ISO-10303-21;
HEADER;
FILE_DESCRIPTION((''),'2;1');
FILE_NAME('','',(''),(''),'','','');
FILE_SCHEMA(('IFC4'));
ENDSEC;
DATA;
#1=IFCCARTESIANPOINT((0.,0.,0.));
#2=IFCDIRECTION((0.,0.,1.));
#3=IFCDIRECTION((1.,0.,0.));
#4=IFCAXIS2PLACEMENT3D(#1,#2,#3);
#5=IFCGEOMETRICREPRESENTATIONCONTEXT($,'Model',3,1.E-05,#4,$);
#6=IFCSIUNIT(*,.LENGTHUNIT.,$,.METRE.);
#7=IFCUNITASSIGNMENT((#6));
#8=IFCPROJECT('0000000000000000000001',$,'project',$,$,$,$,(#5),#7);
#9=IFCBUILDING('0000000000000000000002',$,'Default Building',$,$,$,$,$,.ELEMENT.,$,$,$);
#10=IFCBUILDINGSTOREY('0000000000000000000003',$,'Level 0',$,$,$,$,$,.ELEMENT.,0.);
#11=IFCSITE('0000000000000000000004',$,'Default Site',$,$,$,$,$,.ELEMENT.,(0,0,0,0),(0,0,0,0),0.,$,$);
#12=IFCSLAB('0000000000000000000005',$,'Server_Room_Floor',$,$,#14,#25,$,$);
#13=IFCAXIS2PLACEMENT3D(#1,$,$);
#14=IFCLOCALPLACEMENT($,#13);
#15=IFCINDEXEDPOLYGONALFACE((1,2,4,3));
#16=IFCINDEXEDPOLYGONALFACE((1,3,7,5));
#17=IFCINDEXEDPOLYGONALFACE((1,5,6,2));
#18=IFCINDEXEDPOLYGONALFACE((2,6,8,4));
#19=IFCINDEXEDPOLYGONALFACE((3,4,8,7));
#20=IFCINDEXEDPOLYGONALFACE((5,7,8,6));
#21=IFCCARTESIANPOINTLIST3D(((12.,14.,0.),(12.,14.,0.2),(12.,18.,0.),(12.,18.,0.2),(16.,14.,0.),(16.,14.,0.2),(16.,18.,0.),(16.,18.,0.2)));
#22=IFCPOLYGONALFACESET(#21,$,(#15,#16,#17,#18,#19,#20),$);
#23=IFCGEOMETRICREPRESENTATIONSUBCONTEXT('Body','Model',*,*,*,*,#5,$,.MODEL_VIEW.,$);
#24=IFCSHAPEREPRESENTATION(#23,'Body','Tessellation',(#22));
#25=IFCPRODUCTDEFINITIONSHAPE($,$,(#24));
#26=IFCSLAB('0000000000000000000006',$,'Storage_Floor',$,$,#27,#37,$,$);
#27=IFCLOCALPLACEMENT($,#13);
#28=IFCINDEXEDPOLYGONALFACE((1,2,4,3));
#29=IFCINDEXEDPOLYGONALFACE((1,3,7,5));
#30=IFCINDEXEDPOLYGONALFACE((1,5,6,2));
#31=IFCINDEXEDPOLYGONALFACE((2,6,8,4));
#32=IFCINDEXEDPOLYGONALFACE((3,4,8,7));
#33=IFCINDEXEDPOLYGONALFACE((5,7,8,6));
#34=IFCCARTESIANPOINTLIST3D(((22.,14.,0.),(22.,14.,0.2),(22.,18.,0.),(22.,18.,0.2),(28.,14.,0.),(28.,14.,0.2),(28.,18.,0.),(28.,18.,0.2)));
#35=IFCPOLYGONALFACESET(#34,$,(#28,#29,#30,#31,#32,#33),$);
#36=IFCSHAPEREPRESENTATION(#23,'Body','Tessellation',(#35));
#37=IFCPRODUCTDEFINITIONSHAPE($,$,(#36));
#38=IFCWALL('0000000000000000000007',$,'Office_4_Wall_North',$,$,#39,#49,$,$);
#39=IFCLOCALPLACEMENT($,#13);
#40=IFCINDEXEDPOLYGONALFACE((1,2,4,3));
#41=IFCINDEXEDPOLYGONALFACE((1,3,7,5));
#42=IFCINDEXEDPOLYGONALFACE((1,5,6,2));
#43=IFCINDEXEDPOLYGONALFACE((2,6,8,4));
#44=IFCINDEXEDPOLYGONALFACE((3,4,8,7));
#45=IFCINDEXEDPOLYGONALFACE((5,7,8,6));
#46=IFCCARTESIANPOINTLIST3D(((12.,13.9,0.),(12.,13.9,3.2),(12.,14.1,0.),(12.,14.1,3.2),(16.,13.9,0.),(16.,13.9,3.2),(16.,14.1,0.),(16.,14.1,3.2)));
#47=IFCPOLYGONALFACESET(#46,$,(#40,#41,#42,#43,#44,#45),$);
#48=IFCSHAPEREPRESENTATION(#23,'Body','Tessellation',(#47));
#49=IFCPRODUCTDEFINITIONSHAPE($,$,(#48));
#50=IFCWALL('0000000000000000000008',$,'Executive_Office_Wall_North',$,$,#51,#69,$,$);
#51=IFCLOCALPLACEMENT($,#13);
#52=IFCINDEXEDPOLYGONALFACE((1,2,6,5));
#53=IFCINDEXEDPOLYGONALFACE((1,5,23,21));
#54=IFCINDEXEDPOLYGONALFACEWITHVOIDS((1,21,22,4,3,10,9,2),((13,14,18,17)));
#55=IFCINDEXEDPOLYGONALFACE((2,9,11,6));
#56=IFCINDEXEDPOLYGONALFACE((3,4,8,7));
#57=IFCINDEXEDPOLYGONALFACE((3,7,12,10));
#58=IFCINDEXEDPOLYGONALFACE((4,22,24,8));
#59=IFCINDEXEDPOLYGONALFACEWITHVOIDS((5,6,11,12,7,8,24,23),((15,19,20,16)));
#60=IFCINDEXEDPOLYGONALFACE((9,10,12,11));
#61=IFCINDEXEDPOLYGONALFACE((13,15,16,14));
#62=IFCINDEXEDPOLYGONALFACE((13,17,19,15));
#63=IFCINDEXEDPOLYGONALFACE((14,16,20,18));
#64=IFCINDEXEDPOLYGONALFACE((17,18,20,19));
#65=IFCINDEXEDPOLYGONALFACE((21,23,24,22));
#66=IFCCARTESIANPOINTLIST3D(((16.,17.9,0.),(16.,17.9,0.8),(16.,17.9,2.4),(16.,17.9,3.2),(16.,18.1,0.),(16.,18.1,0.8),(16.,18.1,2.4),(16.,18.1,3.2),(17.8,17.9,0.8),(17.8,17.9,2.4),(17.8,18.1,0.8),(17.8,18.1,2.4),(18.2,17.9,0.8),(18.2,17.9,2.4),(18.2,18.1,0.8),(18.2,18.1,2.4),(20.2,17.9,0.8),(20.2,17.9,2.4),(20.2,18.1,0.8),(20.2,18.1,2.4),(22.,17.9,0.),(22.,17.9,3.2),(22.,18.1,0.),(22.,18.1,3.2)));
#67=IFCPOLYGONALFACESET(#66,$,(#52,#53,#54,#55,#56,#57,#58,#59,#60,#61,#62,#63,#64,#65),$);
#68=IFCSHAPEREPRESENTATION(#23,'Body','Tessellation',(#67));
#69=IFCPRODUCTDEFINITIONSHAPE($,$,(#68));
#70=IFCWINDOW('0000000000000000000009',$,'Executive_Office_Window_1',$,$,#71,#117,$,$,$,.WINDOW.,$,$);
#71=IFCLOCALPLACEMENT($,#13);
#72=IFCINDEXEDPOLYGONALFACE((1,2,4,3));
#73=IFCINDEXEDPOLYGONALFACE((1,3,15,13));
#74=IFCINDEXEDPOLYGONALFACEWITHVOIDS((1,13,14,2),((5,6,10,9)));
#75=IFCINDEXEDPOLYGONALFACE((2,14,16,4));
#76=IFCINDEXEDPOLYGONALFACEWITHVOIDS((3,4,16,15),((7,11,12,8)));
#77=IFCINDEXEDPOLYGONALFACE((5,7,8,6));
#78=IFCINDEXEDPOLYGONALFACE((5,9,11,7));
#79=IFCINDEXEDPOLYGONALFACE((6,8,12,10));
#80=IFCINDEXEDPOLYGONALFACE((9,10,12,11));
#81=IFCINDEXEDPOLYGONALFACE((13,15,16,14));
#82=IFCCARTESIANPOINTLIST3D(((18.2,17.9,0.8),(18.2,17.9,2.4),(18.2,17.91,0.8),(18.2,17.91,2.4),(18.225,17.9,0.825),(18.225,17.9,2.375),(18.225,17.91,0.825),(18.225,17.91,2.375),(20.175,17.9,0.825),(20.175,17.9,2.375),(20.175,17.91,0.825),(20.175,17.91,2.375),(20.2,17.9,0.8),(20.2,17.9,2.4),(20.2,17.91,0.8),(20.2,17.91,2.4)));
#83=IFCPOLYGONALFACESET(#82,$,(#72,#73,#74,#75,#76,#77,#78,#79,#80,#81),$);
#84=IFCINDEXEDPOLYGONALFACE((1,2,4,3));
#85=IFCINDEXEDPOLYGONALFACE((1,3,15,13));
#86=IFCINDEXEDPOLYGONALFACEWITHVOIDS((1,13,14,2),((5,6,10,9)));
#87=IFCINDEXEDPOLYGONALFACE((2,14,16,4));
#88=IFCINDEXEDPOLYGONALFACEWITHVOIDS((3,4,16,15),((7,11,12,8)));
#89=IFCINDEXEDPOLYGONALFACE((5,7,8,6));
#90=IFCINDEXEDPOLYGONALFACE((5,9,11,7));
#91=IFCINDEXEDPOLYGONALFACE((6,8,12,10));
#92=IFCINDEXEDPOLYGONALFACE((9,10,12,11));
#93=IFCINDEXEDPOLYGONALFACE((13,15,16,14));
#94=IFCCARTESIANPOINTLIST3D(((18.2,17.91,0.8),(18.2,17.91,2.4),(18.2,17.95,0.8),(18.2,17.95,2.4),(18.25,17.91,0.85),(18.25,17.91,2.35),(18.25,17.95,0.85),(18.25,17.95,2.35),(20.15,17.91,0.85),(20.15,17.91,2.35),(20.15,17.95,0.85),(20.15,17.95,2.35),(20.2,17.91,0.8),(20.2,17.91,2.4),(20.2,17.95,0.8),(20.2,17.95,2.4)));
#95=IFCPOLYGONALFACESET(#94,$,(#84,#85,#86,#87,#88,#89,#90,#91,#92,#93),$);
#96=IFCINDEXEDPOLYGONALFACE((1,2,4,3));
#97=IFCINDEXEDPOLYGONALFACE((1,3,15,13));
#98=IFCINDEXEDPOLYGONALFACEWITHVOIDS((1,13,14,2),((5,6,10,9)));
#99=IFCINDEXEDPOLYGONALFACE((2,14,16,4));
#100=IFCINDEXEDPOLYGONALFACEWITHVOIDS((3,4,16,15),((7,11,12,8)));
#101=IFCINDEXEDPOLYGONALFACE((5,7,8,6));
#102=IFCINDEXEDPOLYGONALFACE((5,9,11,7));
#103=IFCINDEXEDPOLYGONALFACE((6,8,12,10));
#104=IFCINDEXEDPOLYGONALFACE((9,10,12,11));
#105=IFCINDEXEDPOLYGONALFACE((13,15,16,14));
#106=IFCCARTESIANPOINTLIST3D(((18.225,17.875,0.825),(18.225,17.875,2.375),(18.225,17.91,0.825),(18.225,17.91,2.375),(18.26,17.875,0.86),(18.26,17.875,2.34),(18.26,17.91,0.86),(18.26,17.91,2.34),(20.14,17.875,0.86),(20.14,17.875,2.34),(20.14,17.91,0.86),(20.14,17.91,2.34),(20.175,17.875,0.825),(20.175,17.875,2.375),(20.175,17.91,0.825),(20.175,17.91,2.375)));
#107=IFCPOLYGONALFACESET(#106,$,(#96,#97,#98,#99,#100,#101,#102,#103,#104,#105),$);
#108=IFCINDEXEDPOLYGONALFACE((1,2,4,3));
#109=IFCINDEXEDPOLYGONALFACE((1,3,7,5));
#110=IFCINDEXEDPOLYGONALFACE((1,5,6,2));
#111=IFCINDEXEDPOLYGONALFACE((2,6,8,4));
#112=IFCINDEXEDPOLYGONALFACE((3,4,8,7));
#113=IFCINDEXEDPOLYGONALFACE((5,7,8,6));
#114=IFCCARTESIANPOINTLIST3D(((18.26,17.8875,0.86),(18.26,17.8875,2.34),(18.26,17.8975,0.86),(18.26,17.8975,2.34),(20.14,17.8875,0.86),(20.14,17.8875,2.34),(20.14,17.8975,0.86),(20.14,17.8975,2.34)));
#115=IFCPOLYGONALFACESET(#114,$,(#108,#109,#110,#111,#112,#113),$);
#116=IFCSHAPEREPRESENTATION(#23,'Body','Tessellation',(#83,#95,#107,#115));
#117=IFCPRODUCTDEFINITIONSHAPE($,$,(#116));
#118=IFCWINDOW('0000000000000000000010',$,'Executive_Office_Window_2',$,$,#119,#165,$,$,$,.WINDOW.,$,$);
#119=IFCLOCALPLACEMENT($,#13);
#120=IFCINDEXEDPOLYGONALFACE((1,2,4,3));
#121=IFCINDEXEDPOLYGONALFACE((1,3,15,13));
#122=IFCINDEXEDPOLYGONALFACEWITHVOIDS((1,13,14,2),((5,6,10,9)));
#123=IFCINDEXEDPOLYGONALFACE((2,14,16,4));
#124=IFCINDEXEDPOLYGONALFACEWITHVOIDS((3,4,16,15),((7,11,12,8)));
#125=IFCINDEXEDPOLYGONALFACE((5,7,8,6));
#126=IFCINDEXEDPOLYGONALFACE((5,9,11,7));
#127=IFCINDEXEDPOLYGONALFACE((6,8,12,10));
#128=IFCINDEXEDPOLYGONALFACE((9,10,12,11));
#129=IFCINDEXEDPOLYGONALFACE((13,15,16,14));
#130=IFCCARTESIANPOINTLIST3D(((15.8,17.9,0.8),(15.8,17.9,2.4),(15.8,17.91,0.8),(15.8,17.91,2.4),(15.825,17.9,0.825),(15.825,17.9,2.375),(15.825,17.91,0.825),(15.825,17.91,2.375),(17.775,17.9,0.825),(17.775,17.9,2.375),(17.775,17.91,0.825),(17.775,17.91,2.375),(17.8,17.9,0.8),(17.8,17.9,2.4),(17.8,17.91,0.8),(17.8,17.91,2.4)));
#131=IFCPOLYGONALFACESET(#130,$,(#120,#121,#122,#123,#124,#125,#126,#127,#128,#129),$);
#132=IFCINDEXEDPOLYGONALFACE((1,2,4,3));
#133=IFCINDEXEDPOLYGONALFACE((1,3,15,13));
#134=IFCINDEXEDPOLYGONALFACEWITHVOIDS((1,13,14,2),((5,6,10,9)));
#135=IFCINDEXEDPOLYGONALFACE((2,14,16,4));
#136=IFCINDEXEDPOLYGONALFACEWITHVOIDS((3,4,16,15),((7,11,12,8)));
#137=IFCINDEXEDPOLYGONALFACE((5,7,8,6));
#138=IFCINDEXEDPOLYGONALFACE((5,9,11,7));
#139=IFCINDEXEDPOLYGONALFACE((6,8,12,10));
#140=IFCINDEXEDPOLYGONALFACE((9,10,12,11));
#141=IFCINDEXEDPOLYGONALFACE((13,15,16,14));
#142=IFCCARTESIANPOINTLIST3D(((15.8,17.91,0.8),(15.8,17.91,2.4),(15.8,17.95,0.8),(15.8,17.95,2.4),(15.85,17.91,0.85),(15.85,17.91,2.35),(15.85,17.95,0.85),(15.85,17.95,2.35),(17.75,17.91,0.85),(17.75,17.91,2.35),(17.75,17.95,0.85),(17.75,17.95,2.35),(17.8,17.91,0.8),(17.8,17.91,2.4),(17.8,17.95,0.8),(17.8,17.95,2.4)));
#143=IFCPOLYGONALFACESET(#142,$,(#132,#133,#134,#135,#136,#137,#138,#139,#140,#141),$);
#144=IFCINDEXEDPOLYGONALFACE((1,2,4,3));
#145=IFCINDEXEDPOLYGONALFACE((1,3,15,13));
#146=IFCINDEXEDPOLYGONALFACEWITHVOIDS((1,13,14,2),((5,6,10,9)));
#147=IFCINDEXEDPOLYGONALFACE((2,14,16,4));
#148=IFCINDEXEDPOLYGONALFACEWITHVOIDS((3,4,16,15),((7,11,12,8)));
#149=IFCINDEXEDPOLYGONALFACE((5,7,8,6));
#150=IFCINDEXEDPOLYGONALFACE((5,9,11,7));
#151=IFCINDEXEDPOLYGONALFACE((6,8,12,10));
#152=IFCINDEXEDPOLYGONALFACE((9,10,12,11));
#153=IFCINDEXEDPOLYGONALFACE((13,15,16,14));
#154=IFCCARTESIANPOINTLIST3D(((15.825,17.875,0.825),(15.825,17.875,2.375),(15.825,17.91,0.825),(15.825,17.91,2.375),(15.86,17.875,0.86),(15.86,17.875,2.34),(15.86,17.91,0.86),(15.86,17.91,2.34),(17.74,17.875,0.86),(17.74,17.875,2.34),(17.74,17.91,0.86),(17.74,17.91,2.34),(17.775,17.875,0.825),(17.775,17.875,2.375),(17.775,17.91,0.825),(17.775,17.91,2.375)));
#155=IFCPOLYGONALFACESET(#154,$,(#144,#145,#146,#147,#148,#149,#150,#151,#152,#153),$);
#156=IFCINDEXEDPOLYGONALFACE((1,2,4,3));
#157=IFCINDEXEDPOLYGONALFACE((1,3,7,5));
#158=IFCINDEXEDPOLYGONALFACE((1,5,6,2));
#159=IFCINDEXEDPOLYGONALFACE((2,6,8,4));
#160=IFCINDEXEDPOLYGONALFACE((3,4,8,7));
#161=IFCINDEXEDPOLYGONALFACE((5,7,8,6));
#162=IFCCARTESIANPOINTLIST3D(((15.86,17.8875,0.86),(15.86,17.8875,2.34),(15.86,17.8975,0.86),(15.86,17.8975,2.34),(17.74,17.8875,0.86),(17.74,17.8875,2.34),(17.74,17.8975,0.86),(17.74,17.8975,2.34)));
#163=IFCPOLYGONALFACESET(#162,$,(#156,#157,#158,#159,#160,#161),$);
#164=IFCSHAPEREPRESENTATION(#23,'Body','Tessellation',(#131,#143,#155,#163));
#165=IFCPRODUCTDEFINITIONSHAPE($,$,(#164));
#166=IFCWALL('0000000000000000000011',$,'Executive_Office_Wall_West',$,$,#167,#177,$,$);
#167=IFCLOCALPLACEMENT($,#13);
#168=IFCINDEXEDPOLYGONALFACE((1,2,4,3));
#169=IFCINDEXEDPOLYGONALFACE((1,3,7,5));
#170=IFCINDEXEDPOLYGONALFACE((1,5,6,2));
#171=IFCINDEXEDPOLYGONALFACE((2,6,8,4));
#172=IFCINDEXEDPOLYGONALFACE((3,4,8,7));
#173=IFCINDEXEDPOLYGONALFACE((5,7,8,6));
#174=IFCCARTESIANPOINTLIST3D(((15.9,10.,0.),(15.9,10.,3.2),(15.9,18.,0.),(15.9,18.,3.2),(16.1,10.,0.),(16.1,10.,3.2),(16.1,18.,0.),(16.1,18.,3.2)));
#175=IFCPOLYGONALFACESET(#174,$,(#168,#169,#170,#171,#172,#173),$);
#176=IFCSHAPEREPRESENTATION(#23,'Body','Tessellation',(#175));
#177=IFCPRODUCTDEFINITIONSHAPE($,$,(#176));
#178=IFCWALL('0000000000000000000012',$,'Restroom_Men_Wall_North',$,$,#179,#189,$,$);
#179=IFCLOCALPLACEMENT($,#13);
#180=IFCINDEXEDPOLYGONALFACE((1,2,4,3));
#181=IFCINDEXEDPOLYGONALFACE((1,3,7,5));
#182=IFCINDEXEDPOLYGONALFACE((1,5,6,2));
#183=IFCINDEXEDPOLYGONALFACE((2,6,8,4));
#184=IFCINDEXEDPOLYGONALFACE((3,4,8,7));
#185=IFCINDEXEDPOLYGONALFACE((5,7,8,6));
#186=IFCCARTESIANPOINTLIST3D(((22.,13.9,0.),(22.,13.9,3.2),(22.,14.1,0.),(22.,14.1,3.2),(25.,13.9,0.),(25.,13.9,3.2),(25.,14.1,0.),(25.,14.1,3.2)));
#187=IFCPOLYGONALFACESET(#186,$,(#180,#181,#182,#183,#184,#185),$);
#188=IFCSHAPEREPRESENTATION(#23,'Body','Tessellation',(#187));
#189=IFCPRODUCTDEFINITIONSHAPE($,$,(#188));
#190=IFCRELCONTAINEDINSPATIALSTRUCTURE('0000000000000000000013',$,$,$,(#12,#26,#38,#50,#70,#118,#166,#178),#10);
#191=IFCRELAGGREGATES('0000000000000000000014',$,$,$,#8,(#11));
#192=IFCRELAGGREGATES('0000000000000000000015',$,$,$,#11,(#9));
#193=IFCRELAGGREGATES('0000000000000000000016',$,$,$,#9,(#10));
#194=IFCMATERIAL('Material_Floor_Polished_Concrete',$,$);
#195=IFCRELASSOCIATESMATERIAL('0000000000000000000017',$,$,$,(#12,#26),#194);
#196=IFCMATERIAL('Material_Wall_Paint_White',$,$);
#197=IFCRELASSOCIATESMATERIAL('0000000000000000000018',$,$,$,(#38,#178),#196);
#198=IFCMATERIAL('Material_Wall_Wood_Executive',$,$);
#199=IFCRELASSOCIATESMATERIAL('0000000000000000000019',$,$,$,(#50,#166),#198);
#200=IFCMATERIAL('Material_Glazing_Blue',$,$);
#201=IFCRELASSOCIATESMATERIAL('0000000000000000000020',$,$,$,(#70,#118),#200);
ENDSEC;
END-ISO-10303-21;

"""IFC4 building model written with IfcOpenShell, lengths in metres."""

from ifc_helpers import new_model, si_unit, frame, origin_with_axes, place, context, subcontext, project, spatial, line, indexed_curve, outline, extrude, material, element, fill, save


model = new_model("IFC4")

# Units and contexts
model_context = context("Model", 3, precision=1e-05, world=origin_with_axes())
body_context = subcontext(model_context, "Body", "Model", "MODEL_VIEW")
ifc_project = project(units=[si_unit("LENGTHUNIT", "METRE")], contexts=[model_context])

# Site, building, storey
site = spatial("IfcSite", under=ifc_project, Name="Default Site", CompositionType="ELEMENT", RefLatitude=(0, 0, 0, 0), RefLongitude=(0, 0, 0, 0), RefElevation=0.0)
building = spatial("IfcBuilding", under=site, Name="Default Building", CompositionType="ELEMENT")
storey = spatial("IfcBuildingStorey", under=building, Name="Level 0", CompositionType="ELEMENT", Elevation=0.0)

# Slabs
ifc_material_1 = material(Name="Material_Floor_Polished_Concrete")
slab_placement = place(None, frame((12.0, 14.0, 0.0), z_axis=(0.0, 0.0, 1.0), x_axis=(1.0, 0.0, 0.0)))
element("IfcSlab", 1, at=slab_placement, inside=storey, material=ifc_material_1, Name="Server_Room_Floor", context=body_context, shape_type="SweptSolid", body=[
    extrude(outline(indexed_curve([(0.0, 0.0), (4.0, 0.0), (4.0, 4.0), (0.0, 4.0)])), None, (0.0, 0.0, 1.0), 0.2),
])
for number, where, z_axis, x_axis, name in (
    (2, (22.0, 14.0, 0.0), (0.0, 0.0, 1.0), (1.0, 0.0, 0.0), "Storage_Floor"),
):
    element("IfcSlab", number, at=place(None, frame(where, z_axis=z_axis, x_axis=x_axis)), inside=storey, material=ifc_material_1, Name=name, context=body_context, shape_type="SweptSolid", body=[
        extrude(outline(indexed_curve([(0.0, 0.0), (6.0, 0.0), (6.0, 4.0), (0.0, 4.0)])), None, (0.0, 0.0, 1.0), 0.2),
    ])

# Wall
ifc_material_2 = material(Name="Material_Wall_Paint_White")
wall_1_placement = place(None, frame((16.0, 14.0, 0.0), z_axis=(0.0, 0.0, 1.0), x_axis=(-1.0, 0.0, 0.0)))
element("IfcWall", 3, at=wall_1_placement, inside=storey, material=ifc_material_2, Name="Office_4_Wall_North", context=body_context, shape_type="SweptSolid", body=[
    extrude(outline(indexed_curve([(0.0, 0.0), (0.0, 0.2), (4.0, 0.2), (4.0, 0.0), (0.0, 0.0)], self_intersect=False)), frame((0.0, -0.1, 0.0), z_axis=(0.0, 0.0, 1.0), x_axis=(1.0, 0.0, 0.0)), (0.0, 0.0, 1.0), 3.2),
])

# Wall, openings, windows
ifc_material_3 = material(Name="Material_Wall_Wood_Executive")
wall_2_placement = place(None, frame((22.0, 18.0, 0.0), z_axis=(0.0, 0.0, 1.0), x_axis=(-1.0, 0.0, 0.0)))
wall_2 = element("IfcWall", 4, at=wall_2_placement, inside=storey, material=ifc_material_3, Name="Executive_Office_Wall_North", context=body_context, shape_type="SweptSolid", body=[
    extrude(outline(indexed_curve([(0.0, 0.0), (0.0, 0.2), (6.0, 0.2), (6.0, 0.0), (0.0, 0.0)], self_intersect=False)), frame((0.0, -0.1, 0.0), z_axis=(0.0, 0.0, 1.0), x_axis=(1.0, 0.0, 0.0)), (0.0, 0.0, 1.0), 3.2),
])
opening_1_placement = place(wall_2_placement, frame((1.8, -0.5, 0.8), z_axis=(0.0, 0.0, 1.0), x_axis=(1.0, 0.0, 0.0)))
opening_1 = element("IfcOpeningElement", 5, at=opening_1_placement, inside=storey, cuts=wall_2, PredefinedType="OPENING", context=body_context, shape_type="SweptSolid", body=[
    extrude(outline(indexed_curve([(0.0, 0.0), (0.0, 1.0), (2.0, 1.0), (2.0, 0.0), (0.0, 0.0)], self_intersect=False)), origin_with_axes(), (0.0, 0.0, 1.0), 1.6),
])
opening_2_placement = place(wall_2_placement, frame((4.2, -0.5, 0.8), z_axis=(0.0, 0.0, 1.0), x_axis=(1.0, 0.0, 0.0)))
opening_2 = element("IfcOpeningElement", 6, at=opening_2_placement, inside=storey, cuts=wall_2, PredefinedType="OPENING", context=body_context, shape_type="SweptSolid", body=[
    extrude(outline(indexed_curve([(0.0, 0.0), (0.0, 1.0), (2.0, 1.0), (2.0, 0.0), (0.0, 0.0)], self_intersect=False)), origin_with_axes(), (0.0, 0.0, 1.0), 1.6),
])
ifc_material_4 = material(Name="Material_Glazing_Blue")
window_1_placement = place(None, frame((20.2, 18.0, 0.8), z_axis=(0.0, 0.0, 1.0), x_axis=(-1.0, 0.0, 0.0)))
window_1 = element("IfcWindow", 7, at=window_1_placement, inside=storey, material=ifc_material_4, Name="Executive_Office_Window_1", PredefinedType="WINDOW", context=body_context, shape_type="SweptSolid", body=[
    extrude(outline(indexed_curve([(0.0, 0.0), (2.0, 0.0), (2.0, 1.6), (0.0, 1.6)], segments=[line(1, 2, 3, 4, 1)]), holes=[indexed_curve([(0.025, 0.025), (1.975, 0.025), (1.975, 1.575), (0.025, 1.575)], segments=[line(1, 2, 3, 4, 1)])]), frame((0.0, 0.09, 0.0), z_axis=(0.0, -1.0, 0.0), x_axis=(1.0, 0.0, 0.0)), (0.0, 0.0, -1.0), 0.01),
    extrude(outline(indexed_curve([(0.0, 0.0), (2.0, 0.0), (2.0, 1.6), (0.0, 1.6)], segments=[line(1, 2, 3, 4, 1)]), holes=[indexed_curve([(0.05, 0.05), (1.95, 0.05), (1.95, 1.55), (0.05, 1.55)], segments=[line(1, 2, 3, 4, 1)])]), frame((0.0, 0.05, 0.0), z_axis=(0.0, -1.0, 0.0), x_axis=(1.0, 0.0, 0.0)), (0.0, 0.0, -1.0), 0.04),
    extrude(outline(indexed_curve([(0.0, 0.0), (1.95, 0.0), (1.95, 1.55), (0.0, 1.55)], segments=[line(1, 2, 3, 4, 1)]), holes=[indexed_curve([(0.035, 0.035), (1.915, 0.035), (1.915, 1.515), (0.035, 1.515)], segments=[line(1, 2, 3, 4, 1)])]), frame((0.025, 0.09, 0.025), z_axis=(0.0, -1.0, 0.0), x_axis=(1.0, 0.0, 0.0)), (0.0, 0.0, -1.0), 0.035),
    extrude(outline(indexed_curve([(0.035, 0.035), (1.915, 0.035), (1.915, 1.515), (0.035, 1.515)], segments=[line(1, 2, 3, 4, 1)])), frame((0.025, 0.1025, 0.025), z_axis=(0.0, -1.0, 0.0), x_axis=(1.0, 0.0, 0.0)), (0.0, 0.0, -1.0), 0.01),
])
fill(opening_1, window_1)
window_2_placement = place(None, frame((17.8, 18.0, 0.8), z_axis=(0.0, 0.0, 1.0), x_axis=(-1.0, 0.0, 0.0)))
window_2 = element("IfcWindow", 8, at=window_2_placement, inside=storey, material=ifc_material_4, Name="Executive_Office_Window_2", PredefinedType="WINDOW", context=body_context, shape_type="SweptSolid", body=[
    extrude(outline(indexed_curve([(0.0, 0.0), (2.0, 0.0), (2.0, 1.6), (0.0, 1.6)], segments=[line(1, 2, 3, 4, 1)]), holes=[indexed_curve([(0.025, 0.025), (1.975, 0.025), (1.975, 1.575), (0.025, 1.575)], segments=[line(1, 2, 3, 4, 1)])]), frame((0.0, 0.09, 0.0), z_axis=(0.0, -1.0, 0.0), x_axis=(1.0, 0.0, 0.0)), (0.0, 0.0, -1.0), 0.01),
    extrude(outline(indexed_curve([(0.0, 0.0), (2.0, 0.0), (2.0, 1.6), (0.0, 1.6)], segments=[line(1, 2, 3, 4, 1)]), holes=[indexed_curve([(0.05, 0.05), (1.95, 0.05), (1.95, 1.55), (0.05, 1.55)], segments=[line(1, 2, 3, 4, 1)])]), frame((0.0, 0.05, 0.0), z_axis=(0.0, -1.0, 0.0), x_axis=(1.0, 0.0, 0.0)), (0.0, 0.0, -1.0), 0.04),
    extrude(outline(indexed_curve([(0.0, 0.0), (1.95, 0.0), (1.95, 1.55), (0.0, 1.55)], segments=[line(1, 2, 3, 4, 1)]), holes=[indexed_curve([(0.035, 0.035), (1.915, 0.035), (1.915, 1.515), (0.035, 1.515)], segments=[line(1, 2, 3, 4, 1)])]), frame((0.025, 0.09, 0.025), z_axis=(0.0, -1.0, 0.0), x_axis=(1.0, 0.0, 0.0)), (0.0, 0.0, -1.0), 0.035),
    extrude(outline(indexed_curve([(0.035, 0.035), (1.915, 0.035), (1.915, 1.515), (0.035, 1.515)], segments=[line(1, 2, 3, 4, 1)])), frame((0.025, 0.1025, 0.025), z_axis=(0.0, -1.0, 0.0), x_axis=(1.0, 0.0, 0.0)), (0.0, 0.0, -1.0), 0.01),
])
fill(opening_2, window_2)

# Walls
wall_3_placement = place(None, frame((16.0, 18.0, 0.0), z_axis=(0.0, 0.0, 1.0), x_axis=(0.0, -1.0, 0.0)))
element("IfcWall", 9, at=wall_3_placement, inside=storey, material=ifc_material_3, Name="Executive_Office_Wall_West", context=body_context, shape_type="SweptSolid", body=[
    extrude(outline(indexed_curve([(0.0, 0.0), (0.0, 0.2), (8.0, 0.2), (8.0, 0.0), (0.0, 0.0)], self_intersect=False)), frame((0.0, -0.1, 0.0), z_axis=(0.0, 0.0, 1.0), x_axis=(1.0, 0.0, 0.0)), (0.0, 0.0, 1.0), 3.2),
])
wall_4_placement = place(None, frame((25.0, 14.0, 0.0), z_axis=(0.0, 0.0, 1.0), x_axis=(-1.0, 0.0, 0.0)))
element("IfcWall", 10, at=wall_4_placement, inside=storey, material=ifc_material_2, Name="Restroom_Men_Wall_North", context=body_context, shape_type="SweptSolid", body=[
    extrude(outline(indexed_curve([(0.0, 0.0), (0.0, 0.2), (3.0, 0.2), (3.0, 0.0), (0.0, 0.0)], self_intersect=False)), frame((0.0, -0.1, 0.0), z_axis=(0.0, 0.0, 1.0), x_axis=(1.0, 0.0, 0.0)), (0.0, 0.0, 1.0), 3.2),
])

save(model, "model.ifc")
